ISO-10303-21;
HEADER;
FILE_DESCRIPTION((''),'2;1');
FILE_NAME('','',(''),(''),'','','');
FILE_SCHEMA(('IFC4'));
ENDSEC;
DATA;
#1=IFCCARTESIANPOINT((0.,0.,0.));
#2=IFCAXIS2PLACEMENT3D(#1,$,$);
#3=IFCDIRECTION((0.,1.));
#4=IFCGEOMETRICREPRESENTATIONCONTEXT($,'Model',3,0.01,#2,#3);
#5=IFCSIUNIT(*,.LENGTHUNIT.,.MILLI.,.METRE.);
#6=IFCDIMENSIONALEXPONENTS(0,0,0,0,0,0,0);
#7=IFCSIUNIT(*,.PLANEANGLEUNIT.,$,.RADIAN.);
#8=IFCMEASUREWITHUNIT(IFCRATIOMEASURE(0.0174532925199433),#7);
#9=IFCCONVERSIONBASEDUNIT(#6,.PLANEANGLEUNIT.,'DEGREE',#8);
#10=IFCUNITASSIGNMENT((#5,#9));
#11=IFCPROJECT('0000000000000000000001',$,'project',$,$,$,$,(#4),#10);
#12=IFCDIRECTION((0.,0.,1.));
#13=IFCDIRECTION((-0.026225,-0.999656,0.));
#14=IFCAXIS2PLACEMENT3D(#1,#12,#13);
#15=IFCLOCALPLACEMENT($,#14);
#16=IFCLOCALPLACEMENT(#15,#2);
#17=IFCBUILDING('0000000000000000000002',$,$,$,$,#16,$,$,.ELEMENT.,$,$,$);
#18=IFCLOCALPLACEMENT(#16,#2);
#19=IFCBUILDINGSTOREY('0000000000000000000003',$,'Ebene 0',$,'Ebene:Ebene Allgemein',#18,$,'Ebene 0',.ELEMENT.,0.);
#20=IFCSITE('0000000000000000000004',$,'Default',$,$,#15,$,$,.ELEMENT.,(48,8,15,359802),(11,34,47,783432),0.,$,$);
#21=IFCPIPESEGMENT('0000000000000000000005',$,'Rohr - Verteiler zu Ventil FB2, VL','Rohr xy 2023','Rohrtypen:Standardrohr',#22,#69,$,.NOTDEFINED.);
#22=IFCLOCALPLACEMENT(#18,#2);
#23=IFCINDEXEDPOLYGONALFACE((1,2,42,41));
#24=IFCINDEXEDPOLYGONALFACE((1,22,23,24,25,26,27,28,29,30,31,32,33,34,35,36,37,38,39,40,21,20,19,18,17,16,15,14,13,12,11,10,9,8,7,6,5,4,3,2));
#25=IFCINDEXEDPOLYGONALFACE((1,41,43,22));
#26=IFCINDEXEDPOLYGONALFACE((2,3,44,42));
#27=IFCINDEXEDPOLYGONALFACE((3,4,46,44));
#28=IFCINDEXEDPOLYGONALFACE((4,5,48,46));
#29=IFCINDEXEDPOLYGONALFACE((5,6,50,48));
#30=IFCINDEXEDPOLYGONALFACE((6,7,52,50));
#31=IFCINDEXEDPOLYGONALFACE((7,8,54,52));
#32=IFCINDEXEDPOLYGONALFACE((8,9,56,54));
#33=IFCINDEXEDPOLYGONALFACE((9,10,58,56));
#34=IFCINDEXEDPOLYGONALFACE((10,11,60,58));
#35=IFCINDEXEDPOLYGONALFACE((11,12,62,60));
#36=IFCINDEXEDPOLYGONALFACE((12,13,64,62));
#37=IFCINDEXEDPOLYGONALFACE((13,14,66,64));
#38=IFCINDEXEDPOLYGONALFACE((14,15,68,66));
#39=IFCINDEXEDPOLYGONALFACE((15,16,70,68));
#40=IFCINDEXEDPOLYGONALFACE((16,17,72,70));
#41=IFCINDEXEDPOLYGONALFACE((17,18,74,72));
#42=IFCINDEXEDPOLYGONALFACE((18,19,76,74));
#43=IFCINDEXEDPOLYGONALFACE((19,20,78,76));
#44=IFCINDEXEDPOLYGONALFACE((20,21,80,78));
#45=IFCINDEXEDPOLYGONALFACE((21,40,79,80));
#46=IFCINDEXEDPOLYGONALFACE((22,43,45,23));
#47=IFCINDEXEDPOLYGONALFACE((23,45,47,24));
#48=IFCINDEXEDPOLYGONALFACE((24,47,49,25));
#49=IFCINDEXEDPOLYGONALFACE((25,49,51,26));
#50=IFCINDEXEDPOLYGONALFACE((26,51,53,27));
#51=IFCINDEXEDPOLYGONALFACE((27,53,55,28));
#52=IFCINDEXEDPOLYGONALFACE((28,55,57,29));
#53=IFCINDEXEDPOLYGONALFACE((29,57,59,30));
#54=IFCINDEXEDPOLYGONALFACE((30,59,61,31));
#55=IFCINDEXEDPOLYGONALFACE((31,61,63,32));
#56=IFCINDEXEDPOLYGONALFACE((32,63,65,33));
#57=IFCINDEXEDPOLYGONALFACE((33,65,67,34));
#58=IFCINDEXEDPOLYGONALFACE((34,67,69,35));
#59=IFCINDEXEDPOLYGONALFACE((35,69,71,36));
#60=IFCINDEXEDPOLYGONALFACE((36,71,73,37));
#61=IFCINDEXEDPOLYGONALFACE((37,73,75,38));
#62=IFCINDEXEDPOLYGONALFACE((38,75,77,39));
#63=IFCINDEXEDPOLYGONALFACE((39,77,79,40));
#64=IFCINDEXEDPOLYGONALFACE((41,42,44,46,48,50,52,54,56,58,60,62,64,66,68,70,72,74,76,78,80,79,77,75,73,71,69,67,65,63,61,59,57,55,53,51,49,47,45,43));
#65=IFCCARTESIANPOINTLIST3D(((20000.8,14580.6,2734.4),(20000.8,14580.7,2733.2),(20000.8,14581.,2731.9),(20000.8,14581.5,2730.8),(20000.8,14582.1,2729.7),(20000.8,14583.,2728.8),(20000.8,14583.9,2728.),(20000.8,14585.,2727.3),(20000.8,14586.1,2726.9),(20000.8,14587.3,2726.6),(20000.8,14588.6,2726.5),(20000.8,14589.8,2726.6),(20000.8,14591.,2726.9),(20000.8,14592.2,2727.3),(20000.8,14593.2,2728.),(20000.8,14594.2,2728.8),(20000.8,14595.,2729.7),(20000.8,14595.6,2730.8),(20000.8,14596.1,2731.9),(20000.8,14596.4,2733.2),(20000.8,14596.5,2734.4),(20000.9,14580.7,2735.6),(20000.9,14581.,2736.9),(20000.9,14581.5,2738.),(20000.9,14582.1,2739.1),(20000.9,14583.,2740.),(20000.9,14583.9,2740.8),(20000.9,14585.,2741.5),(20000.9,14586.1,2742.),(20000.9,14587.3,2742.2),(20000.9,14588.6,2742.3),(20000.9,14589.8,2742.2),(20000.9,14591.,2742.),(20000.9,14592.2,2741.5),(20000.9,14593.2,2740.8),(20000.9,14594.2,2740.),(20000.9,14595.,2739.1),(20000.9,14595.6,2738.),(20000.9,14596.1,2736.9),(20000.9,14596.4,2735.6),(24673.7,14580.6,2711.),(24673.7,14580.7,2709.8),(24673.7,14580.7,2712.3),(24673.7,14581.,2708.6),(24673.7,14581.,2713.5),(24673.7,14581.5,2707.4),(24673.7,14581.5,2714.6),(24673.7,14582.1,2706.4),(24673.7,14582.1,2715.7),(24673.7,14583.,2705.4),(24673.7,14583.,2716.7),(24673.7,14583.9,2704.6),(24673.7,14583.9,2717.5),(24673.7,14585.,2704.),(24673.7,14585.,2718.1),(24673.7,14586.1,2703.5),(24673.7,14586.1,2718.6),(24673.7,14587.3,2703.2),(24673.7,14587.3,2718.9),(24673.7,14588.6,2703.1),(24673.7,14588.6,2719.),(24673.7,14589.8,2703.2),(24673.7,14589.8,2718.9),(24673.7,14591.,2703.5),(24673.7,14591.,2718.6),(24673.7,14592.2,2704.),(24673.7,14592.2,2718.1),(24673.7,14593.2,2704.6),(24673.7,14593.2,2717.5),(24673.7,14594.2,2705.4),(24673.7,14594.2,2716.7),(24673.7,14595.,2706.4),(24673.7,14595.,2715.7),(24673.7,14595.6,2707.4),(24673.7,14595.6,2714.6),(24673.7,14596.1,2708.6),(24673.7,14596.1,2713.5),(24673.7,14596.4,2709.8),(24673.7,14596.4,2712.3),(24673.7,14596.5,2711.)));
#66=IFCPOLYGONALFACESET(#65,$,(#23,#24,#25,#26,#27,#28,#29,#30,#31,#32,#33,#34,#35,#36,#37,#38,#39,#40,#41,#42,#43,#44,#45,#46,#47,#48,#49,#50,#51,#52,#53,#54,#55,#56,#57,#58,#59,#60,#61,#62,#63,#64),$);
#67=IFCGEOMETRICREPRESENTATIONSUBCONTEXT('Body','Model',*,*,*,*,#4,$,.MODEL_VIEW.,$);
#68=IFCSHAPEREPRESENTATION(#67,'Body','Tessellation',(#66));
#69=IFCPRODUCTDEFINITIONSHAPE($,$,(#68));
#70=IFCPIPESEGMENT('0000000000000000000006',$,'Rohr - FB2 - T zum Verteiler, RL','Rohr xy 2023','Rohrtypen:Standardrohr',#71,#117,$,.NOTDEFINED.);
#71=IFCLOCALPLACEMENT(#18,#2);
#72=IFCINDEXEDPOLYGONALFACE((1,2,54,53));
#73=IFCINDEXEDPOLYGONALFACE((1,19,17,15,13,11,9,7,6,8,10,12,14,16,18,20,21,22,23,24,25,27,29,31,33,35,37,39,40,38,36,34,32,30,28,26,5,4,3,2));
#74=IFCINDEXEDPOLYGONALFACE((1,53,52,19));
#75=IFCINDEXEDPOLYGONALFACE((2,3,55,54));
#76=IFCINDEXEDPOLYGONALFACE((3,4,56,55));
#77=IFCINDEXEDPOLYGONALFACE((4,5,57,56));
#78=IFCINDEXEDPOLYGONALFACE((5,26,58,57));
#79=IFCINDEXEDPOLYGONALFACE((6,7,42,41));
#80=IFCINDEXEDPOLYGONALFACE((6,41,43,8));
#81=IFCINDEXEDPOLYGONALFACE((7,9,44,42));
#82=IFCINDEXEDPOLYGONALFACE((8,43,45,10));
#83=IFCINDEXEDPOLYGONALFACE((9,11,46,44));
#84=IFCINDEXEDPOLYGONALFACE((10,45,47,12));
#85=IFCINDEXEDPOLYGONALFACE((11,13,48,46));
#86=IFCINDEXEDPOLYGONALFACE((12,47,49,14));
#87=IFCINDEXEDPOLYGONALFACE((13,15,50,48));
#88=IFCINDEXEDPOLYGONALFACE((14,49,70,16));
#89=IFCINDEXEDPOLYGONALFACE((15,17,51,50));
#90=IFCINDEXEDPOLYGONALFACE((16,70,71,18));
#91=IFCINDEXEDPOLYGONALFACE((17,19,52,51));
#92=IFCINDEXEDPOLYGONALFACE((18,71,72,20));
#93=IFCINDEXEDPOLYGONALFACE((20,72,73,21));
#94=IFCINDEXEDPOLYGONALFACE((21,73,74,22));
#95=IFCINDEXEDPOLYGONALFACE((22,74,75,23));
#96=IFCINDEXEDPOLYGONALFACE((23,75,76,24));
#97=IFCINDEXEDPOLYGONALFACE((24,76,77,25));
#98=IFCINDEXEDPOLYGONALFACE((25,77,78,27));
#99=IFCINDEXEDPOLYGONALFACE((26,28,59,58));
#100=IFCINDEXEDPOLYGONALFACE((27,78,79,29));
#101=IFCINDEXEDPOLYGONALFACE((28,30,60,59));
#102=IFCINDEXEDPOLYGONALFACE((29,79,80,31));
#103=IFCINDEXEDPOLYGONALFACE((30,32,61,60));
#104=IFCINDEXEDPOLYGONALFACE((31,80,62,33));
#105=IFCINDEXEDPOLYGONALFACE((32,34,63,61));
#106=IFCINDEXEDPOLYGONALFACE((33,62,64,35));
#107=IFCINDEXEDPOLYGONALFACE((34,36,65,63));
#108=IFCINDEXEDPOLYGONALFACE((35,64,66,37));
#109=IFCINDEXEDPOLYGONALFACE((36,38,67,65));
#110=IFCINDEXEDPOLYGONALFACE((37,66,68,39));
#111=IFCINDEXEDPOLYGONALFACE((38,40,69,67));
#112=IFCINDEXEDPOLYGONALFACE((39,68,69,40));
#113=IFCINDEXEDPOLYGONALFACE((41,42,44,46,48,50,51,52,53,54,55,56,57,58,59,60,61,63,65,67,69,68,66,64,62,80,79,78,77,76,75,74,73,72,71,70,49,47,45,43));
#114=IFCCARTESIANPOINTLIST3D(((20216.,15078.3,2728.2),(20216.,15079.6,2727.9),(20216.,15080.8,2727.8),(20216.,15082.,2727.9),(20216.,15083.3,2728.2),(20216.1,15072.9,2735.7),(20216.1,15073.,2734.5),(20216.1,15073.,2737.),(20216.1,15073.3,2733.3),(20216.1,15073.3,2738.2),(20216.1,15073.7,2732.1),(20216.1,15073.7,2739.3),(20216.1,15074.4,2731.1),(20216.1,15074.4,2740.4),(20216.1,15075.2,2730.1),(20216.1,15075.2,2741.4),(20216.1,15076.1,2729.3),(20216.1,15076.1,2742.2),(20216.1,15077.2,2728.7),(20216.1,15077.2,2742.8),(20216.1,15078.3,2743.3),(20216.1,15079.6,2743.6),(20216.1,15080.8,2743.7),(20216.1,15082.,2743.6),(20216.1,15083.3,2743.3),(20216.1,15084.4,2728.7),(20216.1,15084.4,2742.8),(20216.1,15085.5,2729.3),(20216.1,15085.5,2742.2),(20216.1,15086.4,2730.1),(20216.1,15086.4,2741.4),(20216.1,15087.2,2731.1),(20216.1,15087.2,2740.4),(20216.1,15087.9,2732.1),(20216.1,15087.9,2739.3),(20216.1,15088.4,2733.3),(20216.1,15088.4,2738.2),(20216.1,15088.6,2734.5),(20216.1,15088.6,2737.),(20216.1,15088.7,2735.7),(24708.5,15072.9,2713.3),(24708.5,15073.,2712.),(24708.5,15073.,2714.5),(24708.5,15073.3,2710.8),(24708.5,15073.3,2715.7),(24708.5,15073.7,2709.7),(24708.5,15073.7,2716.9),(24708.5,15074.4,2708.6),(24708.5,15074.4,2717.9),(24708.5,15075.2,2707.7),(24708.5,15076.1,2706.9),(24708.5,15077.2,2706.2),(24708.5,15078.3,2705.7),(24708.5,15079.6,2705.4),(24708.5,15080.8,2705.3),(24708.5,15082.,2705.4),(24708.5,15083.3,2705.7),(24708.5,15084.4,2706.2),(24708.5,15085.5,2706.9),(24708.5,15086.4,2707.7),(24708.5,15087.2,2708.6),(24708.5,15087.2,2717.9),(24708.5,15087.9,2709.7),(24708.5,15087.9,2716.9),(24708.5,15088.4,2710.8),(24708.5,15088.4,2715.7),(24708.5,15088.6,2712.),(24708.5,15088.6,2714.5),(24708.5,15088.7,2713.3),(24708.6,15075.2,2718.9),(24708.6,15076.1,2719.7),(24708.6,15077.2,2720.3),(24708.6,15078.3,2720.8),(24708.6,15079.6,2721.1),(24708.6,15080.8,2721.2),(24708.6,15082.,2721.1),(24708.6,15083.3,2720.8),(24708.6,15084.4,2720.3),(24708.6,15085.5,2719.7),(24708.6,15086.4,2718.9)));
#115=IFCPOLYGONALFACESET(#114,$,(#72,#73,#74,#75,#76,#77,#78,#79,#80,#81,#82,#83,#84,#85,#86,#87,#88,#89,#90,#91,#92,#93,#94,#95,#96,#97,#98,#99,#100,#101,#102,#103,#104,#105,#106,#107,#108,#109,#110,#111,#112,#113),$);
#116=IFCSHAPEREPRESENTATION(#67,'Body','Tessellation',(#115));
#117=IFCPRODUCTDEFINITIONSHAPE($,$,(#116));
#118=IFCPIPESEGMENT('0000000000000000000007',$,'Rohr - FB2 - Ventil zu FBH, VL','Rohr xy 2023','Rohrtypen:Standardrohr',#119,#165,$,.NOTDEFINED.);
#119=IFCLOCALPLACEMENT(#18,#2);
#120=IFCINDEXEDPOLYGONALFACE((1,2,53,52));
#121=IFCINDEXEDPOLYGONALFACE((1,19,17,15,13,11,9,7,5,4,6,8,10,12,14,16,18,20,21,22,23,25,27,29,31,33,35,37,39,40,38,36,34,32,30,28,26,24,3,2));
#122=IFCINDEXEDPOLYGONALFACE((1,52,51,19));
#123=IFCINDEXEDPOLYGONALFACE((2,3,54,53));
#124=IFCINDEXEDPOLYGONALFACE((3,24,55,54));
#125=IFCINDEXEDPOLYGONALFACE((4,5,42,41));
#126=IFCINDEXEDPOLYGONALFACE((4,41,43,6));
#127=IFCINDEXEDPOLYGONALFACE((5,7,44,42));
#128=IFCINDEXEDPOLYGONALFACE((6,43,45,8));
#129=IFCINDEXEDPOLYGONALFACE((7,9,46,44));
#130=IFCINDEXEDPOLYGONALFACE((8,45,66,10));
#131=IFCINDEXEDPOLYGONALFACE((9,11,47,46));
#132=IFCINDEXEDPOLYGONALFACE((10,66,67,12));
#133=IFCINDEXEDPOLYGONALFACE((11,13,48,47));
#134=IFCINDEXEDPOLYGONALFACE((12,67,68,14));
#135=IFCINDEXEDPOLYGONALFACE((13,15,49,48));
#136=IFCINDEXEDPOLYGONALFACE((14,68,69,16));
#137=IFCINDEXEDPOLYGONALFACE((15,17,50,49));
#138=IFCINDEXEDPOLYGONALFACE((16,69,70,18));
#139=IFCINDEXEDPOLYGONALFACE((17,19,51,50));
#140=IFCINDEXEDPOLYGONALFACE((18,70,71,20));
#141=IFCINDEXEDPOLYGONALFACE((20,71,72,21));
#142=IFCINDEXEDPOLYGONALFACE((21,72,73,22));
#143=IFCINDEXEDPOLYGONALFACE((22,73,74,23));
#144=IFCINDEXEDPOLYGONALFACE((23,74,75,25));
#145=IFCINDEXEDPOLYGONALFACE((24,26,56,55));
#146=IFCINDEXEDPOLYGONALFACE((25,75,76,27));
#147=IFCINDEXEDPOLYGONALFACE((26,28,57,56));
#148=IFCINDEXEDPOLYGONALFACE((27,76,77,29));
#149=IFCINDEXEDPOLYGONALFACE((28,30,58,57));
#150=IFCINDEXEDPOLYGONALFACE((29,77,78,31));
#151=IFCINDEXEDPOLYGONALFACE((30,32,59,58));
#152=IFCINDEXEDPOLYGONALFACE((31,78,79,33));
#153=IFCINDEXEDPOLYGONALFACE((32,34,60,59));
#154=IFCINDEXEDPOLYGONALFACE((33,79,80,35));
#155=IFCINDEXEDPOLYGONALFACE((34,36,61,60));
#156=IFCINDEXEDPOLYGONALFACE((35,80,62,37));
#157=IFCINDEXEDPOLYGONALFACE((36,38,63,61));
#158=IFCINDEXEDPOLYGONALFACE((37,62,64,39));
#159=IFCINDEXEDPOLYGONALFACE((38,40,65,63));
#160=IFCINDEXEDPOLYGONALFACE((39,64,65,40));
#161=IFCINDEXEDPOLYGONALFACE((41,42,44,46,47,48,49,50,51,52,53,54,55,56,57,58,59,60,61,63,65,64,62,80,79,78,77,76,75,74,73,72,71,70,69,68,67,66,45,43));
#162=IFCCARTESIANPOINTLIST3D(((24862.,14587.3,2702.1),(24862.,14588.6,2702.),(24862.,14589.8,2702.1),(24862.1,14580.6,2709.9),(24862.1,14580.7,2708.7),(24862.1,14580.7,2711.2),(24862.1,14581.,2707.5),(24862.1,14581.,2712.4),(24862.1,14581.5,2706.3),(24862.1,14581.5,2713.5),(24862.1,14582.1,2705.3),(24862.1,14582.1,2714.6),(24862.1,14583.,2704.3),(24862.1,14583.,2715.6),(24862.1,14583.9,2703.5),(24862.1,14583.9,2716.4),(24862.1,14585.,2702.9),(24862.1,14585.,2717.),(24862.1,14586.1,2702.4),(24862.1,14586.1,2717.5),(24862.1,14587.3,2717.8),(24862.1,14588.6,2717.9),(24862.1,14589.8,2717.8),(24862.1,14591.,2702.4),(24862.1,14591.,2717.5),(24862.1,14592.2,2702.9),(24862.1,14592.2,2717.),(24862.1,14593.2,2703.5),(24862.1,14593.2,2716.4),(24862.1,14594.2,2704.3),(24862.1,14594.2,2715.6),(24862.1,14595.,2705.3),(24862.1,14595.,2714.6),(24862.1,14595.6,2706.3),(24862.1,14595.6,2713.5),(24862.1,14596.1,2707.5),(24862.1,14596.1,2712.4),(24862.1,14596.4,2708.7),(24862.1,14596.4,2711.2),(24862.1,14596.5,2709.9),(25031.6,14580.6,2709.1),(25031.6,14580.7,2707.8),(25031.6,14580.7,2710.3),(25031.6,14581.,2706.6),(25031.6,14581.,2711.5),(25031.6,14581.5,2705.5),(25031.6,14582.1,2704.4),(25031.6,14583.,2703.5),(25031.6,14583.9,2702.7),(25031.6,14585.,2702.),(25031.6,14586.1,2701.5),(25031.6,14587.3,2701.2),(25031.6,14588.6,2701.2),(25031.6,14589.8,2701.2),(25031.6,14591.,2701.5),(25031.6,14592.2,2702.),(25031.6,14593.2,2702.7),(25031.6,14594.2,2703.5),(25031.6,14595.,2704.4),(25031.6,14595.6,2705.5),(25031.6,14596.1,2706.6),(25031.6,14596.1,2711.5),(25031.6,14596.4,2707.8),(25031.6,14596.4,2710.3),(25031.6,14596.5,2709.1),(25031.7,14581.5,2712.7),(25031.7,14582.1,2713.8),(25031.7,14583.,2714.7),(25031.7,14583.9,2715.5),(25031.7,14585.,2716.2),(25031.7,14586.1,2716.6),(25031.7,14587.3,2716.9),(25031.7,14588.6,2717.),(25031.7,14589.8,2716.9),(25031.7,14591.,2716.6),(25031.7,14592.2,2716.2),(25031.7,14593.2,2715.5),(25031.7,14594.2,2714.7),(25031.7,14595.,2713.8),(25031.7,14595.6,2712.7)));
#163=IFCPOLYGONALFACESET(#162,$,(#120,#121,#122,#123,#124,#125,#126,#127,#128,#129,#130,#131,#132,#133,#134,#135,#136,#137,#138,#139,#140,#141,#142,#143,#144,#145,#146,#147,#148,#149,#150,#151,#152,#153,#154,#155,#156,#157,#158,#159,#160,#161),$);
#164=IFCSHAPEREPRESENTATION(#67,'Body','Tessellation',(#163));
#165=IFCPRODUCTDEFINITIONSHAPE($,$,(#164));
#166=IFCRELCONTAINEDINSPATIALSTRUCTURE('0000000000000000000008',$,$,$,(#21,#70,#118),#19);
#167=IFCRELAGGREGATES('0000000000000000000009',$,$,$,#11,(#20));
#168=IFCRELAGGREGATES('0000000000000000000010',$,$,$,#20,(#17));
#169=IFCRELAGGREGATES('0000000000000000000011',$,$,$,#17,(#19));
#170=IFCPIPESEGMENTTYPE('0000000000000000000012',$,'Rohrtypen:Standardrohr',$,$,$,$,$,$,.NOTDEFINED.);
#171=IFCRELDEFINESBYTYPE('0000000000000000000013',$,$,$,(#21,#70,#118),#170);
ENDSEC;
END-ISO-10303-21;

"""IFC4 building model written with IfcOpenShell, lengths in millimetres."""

from ifc_helpers import new_model, entity, si_unit, converted_unit, direction, frame, origin, place, context, subcontext, project, spatial, indexed_curve, outline, extrude, type_object, element, save


model = new_model("IFC4")

# Units and contexts
model_context = context("Model", 3, precision=0.01, world=origin(), true_north=direction((0.0, 1.0)))
body_context = subcontext(model_context, "Body", "Model", "MODEL_VIEW")
ifc_project = project(units=[si_unit("LENGTHUNIT", "METRE", prefix="MILLI"), converted_unit("PLANEANGLEUNIT", "DEGREE", entity("IfcRatioMeasure", 0.0174532925199433), si_unit("PLANEANGLEUNIT", "RADIAN"), dimensions=[0, 0, 0, 0, 0, 0, 0])], contexts=[model_context])

# Site, building, storey
site_placement = place(None, frame((0.0, 0.0, 0.0), z_axis=(0.0, 0.0, 1.0), x_axis=(-0.026225, -0.999656, 0.0)))
site = spatial("IfcSite", under=ifc_project, at=site_placement, Name="Default", CompositionType="ELEMENT", RefLatitude=(48, 8, 15, 359802), RefLongitude=(11, 34, 47, 783432), RefElevation=0.0)
building_placement = place(site_placement, origin())
building = spatial("IfcBuilding", under=site, at=building_placement, CompositionType="ELEMENT")
storey_placement = place(building_placement, origin())
storey = spatial("IfcBuildingStorey", under=building, at=storey_placement, Name="Ebene 0", ObjectType="Ebene:Ebene Allgemein", LongName="Ebene 0", CompositionType="ELEMENT", Elevation=0.0)

# Pipe segments
pipe_segment_type = type_object("IfcPipeSegmentType", Name="Rohrtypen:Standardrohr", PredefinedType="NOTDEFINED")
pipe_segment_1_placement = place(storey_placement, origin())
element("IfcPipeSegment", 1, at=pipe_segment_1_placement, inside=storey, type_object=pipe_segment_type, Name="Rohr - Verteiler zu Ventil FB2, VL", Description="Rohr xy 2023", ObjectType="Rohrtypen:Standardrohr", PredefinedType="NOTDEFINED", context=body_context, shape_type="SweptSolid", body=[
    extrude(outline(indexed_curve([(7.9, 0.0), (7.8, 1.2), (7.6, 2.5), (7.1, 3.6), (6.4, 4.7), (5.6, 5.6), (4.7, 6.4), (3.6, 7.1), (2.5, 7.6), (1.2, 7.8), (0.0, 7.9), (-1.2, 7.8), (-2.5, 7.6), (-3.6, 7.1), (-4.7, 6.4), (-5.6, 5.6), (-6.4, 4.7), (-7.1, 3.6), (-7.6, 2.5), (-7.8, 1.2), (-7.9, 0.0), (-7.8, -1.2), (-7.6, -2.5), (-7.1, -3.6), (-6.4, -4.7), (-5.6, -5.6), (-4.7, -6.4), (-3.6, -7.1), (-2.5, -7.6), (-1.2, -7.8), (0.0, -7.9), (1.2, -7.8), (2.5, -7.6), (3.6, -7.1), (4.7, -6.4), (5.6, -5.6), (6.4, -4.7), (7.1, -3.6), (7.6, -2.5), (7.8, -1.2), (7.9, 0.0)], self_intersect=False)), frame((24673.7, 14588.6, 2711.0), z_axis=(-0.999988, 0.0, 0.005), x_axis=(0.0, 1.0, 0.0)), (0.0, 0.0, 1.0), 4672.9),
])
pipe_segment_2_placement = place(storey_placement, origin())
element("IfcPipeSegment", 2, at=pipe_segment_2_placement, inside=storey, type_object=pipe_segment_type, Name="Rohr - FB2 - T zum Verteiler, RL", Description="Rohr xy 2023", ObjectType="Rohrtypen:Standardrohr", PredefinedType="NOTDEFINED", context=body_context, shape_type="SweptSolid", body=[
    extrude(outline(indexed_curve([(7.9, 0.0), (7.8, 1.2), (7.6, 2.5), (7.1, 3.6), (6.4, 4.7), (5.6, 5.6), (4.7, 6.4), (3.6, 7.1), (2.5, 7.6), (1.2, 7.8), (0.0, 7.9), (-1.2, 7.8), (-2.5, 7.6), (-3.6, 7.1), (-4.7, 6.4), (-5.6, 5.6), (-6.4, 4.7), (-7.1, 3.6), (-7.6, 2.5), (-7.8, 1.2), (-7.9, 0.0), (-7.8, -1.2), (-7.6, -2.5), (-7.1, -3.6), (-6.4, -4.7), (-5.6, -5.6), (-4.7, -6.4), (-3.6, -7.1), (-2.5, -7.6), (-1.2, -7.8), (0.0, -7.9), (1.2, -7.8), (2.5, -7.6), (3.6, -7.1), (4.7, -6.4), (5.6, -5.6), (6.4, -4.7), (7.1, -3.6), (7.6, -2.5), (7.8, -1.2), (7.9, 0.0)], self_intersect=False)), frame((24708.5, 15080.8, 2713.3), z_axis=(-0.999988, 0.0, 0.005), x_axis=(0.0, 1.0, 0.0)), (0.0, 0.0, 1.0), 4492.5),
])
pipe_segment_3_placement = place(storey_placement, origin())
element("IfcPipeSegment", 3, at=pipe_segment_3_placement, inside=storey, type_object=pipe_segment_type, Name="Rohr - FB2 - Ventil zu FBH, VL", Description="Rohr xy 2023", ObjectType="Rohrtypen:Standardrohr", PredefinedType="NOTDEFINED", context=body_context, shape_type="SweptSolid", body=[
    extrude(outline(indexed_curve([(7.9, 0.0), (7.8, 1.2), (7.6, 2.5), (7.1, 3.6), (6.4, 4.7), (5.6, 5.6), (4.7, 6.4), (3.6, 7.1), (2.5, 7.6), (1.2, 7.8), (0.0, 7.9), (-1.2, 7.8), (-2.5, 7.6), (-3.6, 7.1), (-4.7, 6.4), (-5.6, 5.6), (-6.4, 4.7), (-7.1, 3.6), (-7.6, 2.5), (-7.8, 1.2), (-7.9, 0.0), (-7.8, -1.2), (-7.6, -2.5), (-7.1, -3.6), (-6.4, -4.7), (-5.6, -5.6), (-4.7, -6.4), (-3.6, -7.1), (-2.5, -7.6), (-1.2, -7.8), (0.0, -7.9), (1.2, -7.8), (2.5, -7.6), (3.6, -7.1), (4.7, -6.4), (5.6, -5.6), (6.4, -4.7), (7.1, -3.6), (7.6, -2.5), (7.8, -1.2), (7.9, 0.0)], self_intersect=False)), frame((24862.1, 14588.6, 2709.9), z_axis=(0.999988, 0.0, -0.005), x_axis=(0.0, 1.0, 0.0)), (0.0, 0.0, 1.0), 169.5),
])

save(model, "model.ifc")
